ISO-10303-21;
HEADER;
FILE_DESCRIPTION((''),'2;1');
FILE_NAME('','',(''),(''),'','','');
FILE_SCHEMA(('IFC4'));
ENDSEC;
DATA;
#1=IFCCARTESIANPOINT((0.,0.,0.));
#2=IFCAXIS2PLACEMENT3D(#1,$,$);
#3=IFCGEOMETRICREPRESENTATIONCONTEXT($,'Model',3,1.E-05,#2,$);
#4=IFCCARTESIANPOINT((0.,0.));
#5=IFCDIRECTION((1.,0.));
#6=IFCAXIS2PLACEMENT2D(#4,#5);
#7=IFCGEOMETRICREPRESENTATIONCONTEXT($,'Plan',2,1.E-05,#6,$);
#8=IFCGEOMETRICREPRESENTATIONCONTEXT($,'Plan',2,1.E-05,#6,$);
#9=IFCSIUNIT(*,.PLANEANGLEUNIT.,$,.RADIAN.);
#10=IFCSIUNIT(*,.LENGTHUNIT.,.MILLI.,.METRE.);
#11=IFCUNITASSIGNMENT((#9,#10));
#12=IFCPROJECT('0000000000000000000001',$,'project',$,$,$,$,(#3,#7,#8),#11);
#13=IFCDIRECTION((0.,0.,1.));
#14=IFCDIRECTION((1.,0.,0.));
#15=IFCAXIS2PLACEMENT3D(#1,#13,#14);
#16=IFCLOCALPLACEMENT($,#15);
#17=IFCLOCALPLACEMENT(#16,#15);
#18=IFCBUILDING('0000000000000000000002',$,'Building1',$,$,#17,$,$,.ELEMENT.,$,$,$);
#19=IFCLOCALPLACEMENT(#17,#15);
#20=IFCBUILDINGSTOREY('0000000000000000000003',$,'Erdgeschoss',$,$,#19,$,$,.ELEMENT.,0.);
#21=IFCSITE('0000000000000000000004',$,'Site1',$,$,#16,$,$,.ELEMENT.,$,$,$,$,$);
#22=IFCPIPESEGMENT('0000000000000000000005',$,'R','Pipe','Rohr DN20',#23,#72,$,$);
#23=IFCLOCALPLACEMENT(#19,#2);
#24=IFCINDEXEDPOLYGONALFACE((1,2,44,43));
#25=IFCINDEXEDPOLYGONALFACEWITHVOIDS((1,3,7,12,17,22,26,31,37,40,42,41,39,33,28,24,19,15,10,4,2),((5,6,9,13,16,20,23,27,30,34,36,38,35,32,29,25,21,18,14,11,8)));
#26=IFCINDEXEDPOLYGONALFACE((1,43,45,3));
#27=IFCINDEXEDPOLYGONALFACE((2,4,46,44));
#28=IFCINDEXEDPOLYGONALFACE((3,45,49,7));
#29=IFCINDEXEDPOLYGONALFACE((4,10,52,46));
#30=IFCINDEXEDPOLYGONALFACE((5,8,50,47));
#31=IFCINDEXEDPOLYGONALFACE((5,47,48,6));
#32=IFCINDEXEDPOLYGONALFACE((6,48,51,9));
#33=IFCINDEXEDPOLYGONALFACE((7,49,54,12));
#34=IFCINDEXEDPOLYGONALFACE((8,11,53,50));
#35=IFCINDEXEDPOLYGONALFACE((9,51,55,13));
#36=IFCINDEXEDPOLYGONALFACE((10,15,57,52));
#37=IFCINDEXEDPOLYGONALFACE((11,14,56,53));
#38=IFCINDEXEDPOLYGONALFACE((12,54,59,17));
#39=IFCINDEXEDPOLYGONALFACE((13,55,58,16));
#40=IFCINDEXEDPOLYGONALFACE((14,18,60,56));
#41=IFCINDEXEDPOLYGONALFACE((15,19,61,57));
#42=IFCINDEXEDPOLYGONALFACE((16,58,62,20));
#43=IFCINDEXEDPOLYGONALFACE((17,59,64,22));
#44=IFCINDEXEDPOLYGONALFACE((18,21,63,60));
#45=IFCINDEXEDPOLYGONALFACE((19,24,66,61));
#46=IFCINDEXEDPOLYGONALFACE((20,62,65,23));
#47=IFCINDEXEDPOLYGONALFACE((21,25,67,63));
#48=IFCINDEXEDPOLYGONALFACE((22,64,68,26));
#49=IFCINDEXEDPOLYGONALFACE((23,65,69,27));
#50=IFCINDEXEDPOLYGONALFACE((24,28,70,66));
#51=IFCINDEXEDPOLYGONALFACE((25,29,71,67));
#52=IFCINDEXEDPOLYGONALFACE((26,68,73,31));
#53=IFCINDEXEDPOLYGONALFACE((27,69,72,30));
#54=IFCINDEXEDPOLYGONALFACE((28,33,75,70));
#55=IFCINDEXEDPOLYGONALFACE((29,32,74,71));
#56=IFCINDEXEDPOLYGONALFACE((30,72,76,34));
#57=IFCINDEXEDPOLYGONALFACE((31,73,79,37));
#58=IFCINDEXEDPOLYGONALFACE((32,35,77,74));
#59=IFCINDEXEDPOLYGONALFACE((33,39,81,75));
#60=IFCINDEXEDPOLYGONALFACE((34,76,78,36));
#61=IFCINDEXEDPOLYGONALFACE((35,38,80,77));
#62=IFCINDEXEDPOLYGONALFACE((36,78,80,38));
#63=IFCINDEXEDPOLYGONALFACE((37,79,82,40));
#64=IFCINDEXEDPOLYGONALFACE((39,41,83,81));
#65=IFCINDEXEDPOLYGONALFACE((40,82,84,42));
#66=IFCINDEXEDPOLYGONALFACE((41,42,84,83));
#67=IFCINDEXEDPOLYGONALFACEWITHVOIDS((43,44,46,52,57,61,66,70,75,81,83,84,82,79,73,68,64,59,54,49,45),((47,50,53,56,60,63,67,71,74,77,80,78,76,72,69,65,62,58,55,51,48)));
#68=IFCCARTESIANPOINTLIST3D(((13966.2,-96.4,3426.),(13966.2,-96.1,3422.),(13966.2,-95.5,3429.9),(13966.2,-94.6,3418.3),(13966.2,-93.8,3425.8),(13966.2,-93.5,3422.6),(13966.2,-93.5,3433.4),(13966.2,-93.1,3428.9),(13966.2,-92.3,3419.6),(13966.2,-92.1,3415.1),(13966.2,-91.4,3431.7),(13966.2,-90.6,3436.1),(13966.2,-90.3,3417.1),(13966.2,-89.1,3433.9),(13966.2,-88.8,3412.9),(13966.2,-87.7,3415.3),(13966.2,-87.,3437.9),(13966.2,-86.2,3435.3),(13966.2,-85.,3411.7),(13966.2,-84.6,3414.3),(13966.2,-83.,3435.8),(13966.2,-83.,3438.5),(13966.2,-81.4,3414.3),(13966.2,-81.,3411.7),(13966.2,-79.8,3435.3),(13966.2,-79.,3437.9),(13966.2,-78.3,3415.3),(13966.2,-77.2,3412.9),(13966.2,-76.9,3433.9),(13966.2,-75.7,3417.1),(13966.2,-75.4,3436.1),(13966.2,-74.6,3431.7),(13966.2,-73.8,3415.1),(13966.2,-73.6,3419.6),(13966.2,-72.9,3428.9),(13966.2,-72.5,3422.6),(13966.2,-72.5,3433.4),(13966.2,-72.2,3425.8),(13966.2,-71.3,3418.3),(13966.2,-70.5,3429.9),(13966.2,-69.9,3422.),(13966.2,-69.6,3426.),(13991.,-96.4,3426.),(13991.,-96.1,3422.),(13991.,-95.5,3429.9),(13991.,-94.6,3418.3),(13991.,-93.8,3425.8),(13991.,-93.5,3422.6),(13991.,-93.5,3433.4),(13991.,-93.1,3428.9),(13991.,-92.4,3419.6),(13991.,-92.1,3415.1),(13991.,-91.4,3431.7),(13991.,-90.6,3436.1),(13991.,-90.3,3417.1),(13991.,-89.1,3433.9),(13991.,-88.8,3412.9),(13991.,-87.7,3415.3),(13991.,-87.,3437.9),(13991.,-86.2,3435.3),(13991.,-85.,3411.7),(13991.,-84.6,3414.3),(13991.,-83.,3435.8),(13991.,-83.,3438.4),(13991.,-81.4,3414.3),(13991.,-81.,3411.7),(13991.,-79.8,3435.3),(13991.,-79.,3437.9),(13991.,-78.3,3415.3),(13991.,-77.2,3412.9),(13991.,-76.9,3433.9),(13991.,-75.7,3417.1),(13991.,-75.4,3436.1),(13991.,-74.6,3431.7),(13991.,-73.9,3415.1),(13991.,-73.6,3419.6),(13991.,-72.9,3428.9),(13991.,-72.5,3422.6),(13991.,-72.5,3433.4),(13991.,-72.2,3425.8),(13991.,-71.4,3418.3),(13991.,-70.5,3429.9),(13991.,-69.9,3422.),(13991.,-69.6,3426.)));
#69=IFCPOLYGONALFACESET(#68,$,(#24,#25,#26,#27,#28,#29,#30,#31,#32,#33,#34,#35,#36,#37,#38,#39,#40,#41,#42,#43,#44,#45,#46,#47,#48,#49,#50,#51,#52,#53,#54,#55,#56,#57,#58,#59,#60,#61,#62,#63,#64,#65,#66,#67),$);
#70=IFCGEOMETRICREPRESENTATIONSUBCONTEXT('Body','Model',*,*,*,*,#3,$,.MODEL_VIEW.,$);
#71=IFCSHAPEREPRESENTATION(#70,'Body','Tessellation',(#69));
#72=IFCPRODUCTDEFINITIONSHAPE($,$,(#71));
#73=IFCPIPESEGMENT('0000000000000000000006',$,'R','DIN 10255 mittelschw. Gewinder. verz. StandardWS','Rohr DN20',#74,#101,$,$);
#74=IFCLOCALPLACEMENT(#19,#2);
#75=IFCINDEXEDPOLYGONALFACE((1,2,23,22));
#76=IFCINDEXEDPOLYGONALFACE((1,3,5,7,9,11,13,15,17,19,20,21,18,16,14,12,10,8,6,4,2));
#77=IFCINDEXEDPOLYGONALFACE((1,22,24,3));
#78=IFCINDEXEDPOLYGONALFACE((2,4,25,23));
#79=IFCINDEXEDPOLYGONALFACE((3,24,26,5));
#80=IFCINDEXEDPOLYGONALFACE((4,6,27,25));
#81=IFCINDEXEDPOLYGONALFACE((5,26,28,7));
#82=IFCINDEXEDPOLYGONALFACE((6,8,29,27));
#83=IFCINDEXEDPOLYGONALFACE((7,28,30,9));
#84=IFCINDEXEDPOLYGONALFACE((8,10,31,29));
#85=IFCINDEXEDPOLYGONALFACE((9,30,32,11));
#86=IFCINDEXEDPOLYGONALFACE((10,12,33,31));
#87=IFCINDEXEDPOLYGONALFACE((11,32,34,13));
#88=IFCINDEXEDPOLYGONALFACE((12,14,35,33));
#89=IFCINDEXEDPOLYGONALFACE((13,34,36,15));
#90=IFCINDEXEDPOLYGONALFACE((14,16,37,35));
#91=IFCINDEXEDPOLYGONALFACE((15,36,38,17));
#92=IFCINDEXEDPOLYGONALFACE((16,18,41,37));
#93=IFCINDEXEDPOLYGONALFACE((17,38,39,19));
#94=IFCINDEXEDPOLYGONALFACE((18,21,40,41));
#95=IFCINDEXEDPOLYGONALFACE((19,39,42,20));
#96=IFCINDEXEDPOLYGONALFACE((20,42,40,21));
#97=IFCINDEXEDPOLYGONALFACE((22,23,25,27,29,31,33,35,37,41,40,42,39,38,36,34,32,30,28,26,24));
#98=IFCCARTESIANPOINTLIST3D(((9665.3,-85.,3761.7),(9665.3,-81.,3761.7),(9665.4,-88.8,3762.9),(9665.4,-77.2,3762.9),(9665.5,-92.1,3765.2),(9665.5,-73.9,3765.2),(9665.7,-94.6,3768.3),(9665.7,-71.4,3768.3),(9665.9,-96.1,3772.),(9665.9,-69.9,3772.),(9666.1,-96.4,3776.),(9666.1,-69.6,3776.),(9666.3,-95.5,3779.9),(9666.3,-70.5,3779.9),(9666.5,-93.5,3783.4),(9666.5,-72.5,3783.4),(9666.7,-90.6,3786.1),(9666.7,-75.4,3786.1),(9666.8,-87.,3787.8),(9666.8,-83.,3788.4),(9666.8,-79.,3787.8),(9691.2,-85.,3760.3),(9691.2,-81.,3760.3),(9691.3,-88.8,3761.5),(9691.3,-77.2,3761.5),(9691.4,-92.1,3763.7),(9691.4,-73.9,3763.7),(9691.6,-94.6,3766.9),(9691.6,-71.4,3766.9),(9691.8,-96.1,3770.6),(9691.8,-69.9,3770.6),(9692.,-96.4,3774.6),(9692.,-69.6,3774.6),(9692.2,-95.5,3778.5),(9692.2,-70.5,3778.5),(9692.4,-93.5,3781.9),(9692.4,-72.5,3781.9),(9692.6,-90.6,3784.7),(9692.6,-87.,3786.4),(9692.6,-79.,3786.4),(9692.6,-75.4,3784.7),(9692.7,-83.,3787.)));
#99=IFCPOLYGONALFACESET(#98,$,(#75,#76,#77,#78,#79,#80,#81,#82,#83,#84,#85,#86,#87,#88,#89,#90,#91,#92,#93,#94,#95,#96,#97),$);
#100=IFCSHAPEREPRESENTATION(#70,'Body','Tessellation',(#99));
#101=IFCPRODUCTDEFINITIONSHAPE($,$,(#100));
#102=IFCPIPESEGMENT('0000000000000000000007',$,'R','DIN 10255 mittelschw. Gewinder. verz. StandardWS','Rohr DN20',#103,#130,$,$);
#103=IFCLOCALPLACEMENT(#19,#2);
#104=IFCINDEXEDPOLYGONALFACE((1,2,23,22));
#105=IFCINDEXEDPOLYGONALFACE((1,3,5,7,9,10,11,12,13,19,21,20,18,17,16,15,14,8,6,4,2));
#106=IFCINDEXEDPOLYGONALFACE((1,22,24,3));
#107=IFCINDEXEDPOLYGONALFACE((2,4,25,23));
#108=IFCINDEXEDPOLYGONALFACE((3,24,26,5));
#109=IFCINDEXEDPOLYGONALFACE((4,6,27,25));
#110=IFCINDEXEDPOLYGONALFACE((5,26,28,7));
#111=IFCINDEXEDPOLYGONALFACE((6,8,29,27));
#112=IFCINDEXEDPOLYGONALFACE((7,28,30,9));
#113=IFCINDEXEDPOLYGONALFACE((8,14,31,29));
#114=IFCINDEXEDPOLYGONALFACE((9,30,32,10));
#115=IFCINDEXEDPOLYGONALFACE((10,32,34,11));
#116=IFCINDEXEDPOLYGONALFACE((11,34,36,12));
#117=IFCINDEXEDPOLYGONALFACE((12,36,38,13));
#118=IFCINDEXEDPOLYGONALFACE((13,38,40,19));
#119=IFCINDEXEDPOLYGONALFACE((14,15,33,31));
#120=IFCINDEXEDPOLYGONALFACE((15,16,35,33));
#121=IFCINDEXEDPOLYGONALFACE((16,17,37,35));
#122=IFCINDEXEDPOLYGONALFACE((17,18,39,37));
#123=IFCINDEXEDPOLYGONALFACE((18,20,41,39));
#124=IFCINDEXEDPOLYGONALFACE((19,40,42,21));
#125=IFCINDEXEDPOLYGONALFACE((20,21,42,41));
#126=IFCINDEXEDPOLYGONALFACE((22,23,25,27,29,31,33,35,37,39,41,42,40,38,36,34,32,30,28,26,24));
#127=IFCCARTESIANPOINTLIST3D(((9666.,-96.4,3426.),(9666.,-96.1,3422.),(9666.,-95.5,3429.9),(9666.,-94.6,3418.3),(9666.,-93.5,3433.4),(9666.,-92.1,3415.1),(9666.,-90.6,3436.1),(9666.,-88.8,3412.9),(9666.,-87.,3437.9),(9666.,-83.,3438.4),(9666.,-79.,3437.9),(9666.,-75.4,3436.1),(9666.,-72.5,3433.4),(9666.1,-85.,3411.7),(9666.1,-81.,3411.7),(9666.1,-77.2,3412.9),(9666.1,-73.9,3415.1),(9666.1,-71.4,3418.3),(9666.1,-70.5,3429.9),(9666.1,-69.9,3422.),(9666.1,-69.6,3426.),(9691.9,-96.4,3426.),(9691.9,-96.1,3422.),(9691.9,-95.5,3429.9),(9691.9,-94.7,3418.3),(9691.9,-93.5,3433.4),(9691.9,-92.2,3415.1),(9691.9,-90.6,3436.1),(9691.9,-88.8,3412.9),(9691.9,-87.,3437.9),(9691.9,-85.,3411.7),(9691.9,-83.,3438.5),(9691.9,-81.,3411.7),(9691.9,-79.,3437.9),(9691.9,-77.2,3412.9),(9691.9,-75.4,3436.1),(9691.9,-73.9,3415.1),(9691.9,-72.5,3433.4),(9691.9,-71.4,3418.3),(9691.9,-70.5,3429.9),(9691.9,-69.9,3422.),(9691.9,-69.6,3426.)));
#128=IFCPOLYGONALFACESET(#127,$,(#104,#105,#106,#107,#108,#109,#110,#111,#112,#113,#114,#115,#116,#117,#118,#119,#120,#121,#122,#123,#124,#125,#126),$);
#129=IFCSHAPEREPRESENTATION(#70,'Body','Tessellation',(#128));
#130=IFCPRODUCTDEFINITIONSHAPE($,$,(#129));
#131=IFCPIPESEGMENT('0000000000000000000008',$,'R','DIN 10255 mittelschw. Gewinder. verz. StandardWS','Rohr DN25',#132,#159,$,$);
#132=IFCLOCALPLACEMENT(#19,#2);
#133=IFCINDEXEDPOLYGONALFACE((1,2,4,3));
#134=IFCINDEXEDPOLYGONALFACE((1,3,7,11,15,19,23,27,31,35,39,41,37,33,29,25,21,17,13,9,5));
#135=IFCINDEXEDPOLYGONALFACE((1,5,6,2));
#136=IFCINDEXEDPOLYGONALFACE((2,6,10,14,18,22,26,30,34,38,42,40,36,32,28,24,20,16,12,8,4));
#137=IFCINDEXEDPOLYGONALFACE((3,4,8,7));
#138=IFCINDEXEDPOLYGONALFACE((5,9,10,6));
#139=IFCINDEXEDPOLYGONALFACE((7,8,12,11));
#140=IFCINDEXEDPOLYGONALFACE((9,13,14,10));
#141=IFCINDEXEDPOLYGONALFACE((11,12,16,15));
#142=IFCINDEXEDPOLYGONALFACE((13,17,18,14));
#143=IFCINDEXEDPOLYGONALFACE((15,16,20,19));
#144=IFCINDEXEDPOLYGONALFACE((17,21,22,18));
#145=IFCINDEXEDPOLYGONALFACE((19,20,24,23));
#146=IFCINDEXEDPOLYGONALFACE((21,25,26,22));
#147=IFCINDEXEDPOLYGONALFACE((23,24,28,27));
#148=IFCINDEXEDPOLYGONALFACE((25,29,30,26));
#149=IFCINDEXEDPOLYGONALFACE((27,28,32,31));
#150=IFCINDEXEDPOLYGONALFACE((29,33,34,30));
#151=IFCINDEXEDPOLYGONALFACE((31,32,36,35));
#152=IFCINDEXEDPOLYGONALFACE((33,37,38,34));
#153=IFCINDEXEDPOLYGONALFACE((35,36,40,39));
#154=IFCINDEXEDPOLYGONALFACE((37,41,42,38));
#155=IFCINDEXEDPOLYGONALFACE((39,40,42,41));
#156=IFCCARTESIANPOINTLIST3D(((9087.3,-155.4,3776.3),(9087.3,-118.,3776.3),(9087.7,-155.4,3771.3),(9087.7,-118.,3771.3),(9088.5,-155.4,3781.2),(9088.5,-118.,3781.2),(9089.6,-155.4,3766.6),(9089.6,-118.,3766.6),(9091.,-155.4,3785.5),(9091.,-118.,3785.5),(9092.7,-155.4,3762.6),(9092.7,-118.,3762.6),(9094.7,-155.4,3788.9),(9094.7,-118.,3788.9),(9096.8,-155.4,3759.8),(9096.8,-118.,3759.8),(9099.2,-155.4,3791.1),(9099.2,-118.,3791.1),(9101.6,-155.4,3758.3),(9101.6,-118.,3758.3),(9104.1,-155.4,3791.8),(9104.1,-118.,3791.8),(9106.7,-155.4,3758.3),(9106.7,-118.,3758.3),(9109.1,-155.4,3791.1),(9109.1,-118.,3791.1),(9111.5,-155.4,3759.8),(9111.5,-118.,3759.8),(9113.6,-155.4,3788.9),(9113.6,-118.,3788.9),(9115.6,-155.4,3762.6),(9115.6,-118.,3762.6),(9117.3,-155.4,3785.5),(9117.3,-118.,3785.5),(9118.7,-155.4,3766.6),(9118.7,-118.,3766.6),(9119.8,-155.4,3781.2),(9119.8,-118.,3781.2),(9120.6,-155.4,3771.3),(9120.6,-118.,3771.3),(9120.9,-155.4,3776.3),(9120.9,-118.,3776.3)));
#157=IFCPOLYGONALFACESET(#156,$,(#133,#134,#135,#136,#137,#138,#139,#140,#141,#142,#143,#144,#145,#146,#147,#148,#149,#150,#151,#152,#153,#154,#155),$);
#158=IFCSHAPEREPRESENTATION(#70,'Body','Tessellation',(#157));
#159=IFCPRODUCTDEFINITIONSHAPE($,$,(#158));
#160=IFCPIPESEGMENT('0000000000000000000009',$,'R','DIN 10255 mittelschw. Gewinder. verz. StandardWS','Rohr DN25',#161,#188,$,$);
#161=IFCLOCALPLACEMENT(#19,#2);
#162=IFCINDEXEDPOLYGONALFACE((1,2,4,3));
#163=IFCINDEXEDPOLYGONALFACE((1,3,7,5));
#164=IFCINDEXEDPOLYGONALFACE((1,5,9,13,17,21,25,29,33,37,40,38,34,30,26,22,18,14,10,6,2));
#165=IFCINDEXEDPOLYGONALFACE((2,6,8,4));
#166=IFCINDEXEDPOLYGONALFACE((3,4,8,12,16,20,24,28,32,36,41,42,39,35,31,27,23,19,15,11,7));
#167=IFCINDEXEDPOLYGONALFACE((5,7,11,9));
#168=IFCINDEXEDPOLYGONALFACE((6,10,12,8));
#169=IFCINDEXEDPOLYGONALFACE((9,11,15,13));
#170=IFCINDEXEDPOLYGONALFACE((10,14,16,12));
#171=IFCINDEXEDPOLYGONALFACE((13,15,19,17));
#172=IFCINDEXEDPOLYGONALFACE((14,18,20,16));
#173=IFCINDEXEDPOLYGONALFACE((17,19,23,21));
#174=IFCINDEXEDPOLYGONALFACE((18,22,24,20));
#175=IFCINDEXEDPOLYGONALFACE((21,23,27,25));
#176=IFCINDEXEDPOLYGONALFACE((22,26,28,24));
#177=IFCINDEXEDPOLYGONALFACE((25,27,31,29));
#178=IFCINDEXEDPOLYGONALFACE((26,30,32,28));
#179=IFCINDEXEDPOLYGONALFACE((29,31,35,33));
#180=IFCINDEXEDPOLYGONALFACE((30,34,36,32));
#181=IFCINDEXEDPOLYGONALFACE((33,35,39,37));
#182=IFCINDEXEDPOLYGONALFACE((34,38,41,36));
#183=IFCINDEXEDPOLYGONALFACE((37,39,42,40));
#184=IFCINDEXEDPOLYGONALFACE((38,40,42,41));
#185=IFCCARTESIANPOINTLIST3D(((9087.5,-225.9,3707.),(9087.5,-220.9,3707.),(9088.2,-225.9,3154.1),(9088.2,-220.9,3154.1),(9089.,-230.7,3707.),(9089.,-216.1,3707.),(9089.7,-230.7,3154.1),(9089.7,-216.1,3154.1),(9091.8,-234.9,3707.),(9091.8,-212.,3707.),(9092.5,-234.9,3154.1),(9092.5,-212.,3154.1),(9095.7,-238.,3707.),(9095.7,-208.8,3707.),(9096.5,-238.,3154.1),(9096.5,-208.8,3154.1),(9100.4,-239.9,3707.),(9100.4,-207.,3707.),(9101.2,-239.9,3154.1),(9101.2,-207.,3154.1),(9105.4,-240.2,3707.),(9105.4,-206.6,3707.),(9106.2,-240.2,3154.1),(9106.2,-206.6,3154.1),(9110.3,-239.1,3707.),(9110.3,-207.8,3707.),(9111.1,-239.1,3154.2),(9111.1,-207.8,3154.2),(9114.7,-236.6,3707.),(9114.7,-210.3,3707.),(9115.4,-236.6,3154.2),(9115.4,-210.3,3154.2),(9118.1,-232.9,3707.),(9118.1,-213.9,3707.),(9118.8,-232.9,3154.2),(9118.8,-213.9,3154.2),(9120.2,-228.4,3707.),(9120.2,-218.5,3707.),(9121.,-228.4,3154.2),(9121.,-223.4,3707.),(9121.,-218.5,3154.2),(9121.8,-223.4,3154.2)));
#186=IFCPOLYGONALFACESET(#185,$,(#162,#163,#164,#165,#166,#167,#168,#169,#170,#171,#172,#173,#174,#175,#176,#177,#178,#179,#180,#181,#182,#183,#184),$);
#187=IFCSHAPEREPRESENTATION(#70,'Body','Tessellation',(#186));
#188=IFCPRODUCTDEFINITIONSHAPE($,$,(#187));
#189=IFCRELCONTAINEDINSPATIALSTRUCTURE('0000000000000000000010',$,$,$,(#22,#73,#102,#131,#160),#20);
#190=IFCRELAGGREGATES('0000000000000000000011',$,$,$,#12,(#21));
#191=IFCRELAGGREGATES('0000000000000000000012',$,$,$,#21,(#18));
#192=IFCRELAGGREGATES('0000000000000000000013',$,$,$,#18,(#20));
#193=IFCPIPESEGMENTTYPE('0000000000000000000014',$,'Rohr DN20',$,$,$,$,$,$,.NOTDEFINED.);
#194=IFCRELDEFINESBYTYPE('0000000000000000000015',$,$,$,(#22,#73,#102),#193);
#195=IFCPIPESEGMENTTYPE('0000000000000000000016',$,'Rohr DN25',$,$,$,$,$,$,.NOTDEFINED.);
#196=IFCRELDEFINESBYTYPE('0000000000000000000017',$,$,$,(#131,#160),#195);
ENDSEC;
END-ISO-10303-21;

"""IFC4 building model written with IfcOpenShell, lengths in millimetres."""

from ifc_helpers import new_model, si_unit, frame, origin, origin_with_axes, origin_2d_with_axis, place, context, subcontext, project, spatial, circle, hollow_circle, extrude, type_object, element, save


model = new_model("IFC4")

# Units and contexts
model_context = context("Model", 3, precision=1e-05, world=origin())
plan_context_1 = context("Plan", 2, precision=1e-05, world=origin_2d_with_axis())
plan_context_2 = context("Plan", 2, precision=1e-05, world=origin_2d_with_axis())
body_context = subcontext(model_context, "Body", "Model", "MODEL_VIEW")
ifc_project = project(units=[si_unit("PLANEANGLEUNIT", "RADIAN"), si_unit("LENGTHUNIT", "METRE", prefix="MILLI")], contexts=[model_context, plan_context_1, plan_context_2])

# Site, building, storey
site_placement = place(None, origin_with_axes())
site = spatial("IfcSite", under=ifc_project, at=site_placement, Name="Site1", CompositionType="ELEMENT")
building_placement = place(site_placement, origin_with_axes())
building = spatial("IfcBuilding", under=site, at=building_placement, Name="Building1", CompositionType="ELEMENT")
storey_placement = place(building_placement, origin_with_axes())
storey = spatial("IfcBuildingStorey", under=building, at=storey_placement, Name="Erdgeschoss", CompositionType="ELEMENT", Elevation=0.0)

# Pipe segments
pipe_segment_type_1 = type_object("IfcPipeSegmentType", Name="Rohr DN20", PredefinedType="NOTDEFINED")
pipe_segment_1_placement = place(storey_placement, frame((13978.6, -82.8, 3425.0), z_axis=(0.0, 0.0, 1.0), x_axis=(1.0, 0.0, 0.0)))
element("IfcPipeSegment", 1, at=pipe_segment_1_placement, inside=storey, type_object=pipe_segment_type_1, Name="R", Description="Pipe", ObjectType="Rohr DN20", context=body_context, shape_type="SolidModel", body=[
    extrude(hollow_circle(Radius=13.4, WallThickness=2.6, at=origin_2d_with_axis()), frame((-12.4, -0.1, 0.0), z_axis=(1.0, -0.000132, -0.000095), x_axis=(0.0, 0.0, 1.0)), (0.0, 0.0, 1.0), 24.9),
])
pipe_segment_2_placement = place(storey_placement, frame((9679.0, -83.2, 3774.3), z_axis=(0.0, 0.0, 1.0), x_axis=(1.0, 0.0, 0.0)))
element("IfcPipeSegment", 2, at=pipe_segment_2_placement, inside=storey, type_object=pipe_segment_type_1, Name="R", Description="DIN 10255 mittelschw. Gewinder. verz. StandardWS", ObjectType="Rohr DN20", context=body_context, shape_type="SolidModel", body=[
    extrude(circle(Radius=13.4, at=origin_2d_with_axis()), frame((12.9, 0.1, -0.7), z_axis=(-0.99849, 0.0, 0.054935), x_axis=(0.0, 0.0, 1.0)), (0.0, 0.0, 1.0), 25.9),
])
pipe_segment_3_placement = place(storey_placement, frame((9679.0, -83.2, 3425.0), z_axis=(0.0, 0.0, 1.0), x_axis=(1.0, 0.0, 0.0)))
element("IfcPipeSegment", 3, at=pipe_segment_3_placement, inside=storey, type_object=pipe_segment_type_1, Name="R", Description="DIN 10255 mittelschw. Gewinder. verz. StandardWS", ObjectType="Rohr DN20", context=body_context, shape_type="SolidModel", body=[
    extrude(circle(Radius=13.4, at=origin_2d_with_axis()), frame((12.9, 0.1, 0.0), z_axis=(-1.0, 0.000127, -0.000091), x_axis=(0.0, 0.0, 1.0)), (0.0, 0.0, 1.0), 25.8),
])
pipe_segment_type_2 = type_object("IfcPipeSegmentType", Name="Rohr DN25", PredefinedType="NOTDEFINED")
pipe_segment_4_placement = place(storey_placement, frame((9104.3, -136.7, 3775.0), z_axis=(0.0, 0.0, 1.0), x_axis=(1.0, 0.0, 0.0)))
element("IfcPipeSegment", 4, at=pipe_segment_4_placement, inside=storey, type_object=pipe_segment_type_2, Name="R", Description="DIN 10255 mittelschw. Gewinder. verz. StandardWS", ObjectType="Rohr DN25", context=body_context, shape_type="SolidModel", body=[
    extrude(circle(Radius=16.9, at=origin_2d_with_axis()), frame((-0.1, 18.7, 0.0), z_axis=(0.0, -1.0, 0.0), x_axis=(0.0, 0.0, 1.0)), (0.0, 0.0, 1.0), 37.4),
])
pipe_segment_5_placement = place(storey_placement, frame((9104.5, -223.3, 3430.6), z_axis=(0.0, 0.0, 1.0), x_axis=(1.0, 0.0, 0.0)))
element("IfcPipeSegment", 5, at=pipe_segment_5_placement, inside=storey, type_object=pipe_segment_type_2, Name="R", Description="DIN 10255 mittelschw. Gewinder. verz. StandardWS", ObjectType="Rohr DN25", context=body_context, shape_type="SolidModel", body=[
    extrude(circle(Radius=16.9, at=origin_2d_with_axis()), frame((-0.4, -0.2, 276.4), z_axis=(0.001364, 0.0, -0.999999), x_axis=(1.0, 0.0, 0.0)), (0.0, 0.0, 1.0), 552.9),
])

save(model, "model.ifc")
